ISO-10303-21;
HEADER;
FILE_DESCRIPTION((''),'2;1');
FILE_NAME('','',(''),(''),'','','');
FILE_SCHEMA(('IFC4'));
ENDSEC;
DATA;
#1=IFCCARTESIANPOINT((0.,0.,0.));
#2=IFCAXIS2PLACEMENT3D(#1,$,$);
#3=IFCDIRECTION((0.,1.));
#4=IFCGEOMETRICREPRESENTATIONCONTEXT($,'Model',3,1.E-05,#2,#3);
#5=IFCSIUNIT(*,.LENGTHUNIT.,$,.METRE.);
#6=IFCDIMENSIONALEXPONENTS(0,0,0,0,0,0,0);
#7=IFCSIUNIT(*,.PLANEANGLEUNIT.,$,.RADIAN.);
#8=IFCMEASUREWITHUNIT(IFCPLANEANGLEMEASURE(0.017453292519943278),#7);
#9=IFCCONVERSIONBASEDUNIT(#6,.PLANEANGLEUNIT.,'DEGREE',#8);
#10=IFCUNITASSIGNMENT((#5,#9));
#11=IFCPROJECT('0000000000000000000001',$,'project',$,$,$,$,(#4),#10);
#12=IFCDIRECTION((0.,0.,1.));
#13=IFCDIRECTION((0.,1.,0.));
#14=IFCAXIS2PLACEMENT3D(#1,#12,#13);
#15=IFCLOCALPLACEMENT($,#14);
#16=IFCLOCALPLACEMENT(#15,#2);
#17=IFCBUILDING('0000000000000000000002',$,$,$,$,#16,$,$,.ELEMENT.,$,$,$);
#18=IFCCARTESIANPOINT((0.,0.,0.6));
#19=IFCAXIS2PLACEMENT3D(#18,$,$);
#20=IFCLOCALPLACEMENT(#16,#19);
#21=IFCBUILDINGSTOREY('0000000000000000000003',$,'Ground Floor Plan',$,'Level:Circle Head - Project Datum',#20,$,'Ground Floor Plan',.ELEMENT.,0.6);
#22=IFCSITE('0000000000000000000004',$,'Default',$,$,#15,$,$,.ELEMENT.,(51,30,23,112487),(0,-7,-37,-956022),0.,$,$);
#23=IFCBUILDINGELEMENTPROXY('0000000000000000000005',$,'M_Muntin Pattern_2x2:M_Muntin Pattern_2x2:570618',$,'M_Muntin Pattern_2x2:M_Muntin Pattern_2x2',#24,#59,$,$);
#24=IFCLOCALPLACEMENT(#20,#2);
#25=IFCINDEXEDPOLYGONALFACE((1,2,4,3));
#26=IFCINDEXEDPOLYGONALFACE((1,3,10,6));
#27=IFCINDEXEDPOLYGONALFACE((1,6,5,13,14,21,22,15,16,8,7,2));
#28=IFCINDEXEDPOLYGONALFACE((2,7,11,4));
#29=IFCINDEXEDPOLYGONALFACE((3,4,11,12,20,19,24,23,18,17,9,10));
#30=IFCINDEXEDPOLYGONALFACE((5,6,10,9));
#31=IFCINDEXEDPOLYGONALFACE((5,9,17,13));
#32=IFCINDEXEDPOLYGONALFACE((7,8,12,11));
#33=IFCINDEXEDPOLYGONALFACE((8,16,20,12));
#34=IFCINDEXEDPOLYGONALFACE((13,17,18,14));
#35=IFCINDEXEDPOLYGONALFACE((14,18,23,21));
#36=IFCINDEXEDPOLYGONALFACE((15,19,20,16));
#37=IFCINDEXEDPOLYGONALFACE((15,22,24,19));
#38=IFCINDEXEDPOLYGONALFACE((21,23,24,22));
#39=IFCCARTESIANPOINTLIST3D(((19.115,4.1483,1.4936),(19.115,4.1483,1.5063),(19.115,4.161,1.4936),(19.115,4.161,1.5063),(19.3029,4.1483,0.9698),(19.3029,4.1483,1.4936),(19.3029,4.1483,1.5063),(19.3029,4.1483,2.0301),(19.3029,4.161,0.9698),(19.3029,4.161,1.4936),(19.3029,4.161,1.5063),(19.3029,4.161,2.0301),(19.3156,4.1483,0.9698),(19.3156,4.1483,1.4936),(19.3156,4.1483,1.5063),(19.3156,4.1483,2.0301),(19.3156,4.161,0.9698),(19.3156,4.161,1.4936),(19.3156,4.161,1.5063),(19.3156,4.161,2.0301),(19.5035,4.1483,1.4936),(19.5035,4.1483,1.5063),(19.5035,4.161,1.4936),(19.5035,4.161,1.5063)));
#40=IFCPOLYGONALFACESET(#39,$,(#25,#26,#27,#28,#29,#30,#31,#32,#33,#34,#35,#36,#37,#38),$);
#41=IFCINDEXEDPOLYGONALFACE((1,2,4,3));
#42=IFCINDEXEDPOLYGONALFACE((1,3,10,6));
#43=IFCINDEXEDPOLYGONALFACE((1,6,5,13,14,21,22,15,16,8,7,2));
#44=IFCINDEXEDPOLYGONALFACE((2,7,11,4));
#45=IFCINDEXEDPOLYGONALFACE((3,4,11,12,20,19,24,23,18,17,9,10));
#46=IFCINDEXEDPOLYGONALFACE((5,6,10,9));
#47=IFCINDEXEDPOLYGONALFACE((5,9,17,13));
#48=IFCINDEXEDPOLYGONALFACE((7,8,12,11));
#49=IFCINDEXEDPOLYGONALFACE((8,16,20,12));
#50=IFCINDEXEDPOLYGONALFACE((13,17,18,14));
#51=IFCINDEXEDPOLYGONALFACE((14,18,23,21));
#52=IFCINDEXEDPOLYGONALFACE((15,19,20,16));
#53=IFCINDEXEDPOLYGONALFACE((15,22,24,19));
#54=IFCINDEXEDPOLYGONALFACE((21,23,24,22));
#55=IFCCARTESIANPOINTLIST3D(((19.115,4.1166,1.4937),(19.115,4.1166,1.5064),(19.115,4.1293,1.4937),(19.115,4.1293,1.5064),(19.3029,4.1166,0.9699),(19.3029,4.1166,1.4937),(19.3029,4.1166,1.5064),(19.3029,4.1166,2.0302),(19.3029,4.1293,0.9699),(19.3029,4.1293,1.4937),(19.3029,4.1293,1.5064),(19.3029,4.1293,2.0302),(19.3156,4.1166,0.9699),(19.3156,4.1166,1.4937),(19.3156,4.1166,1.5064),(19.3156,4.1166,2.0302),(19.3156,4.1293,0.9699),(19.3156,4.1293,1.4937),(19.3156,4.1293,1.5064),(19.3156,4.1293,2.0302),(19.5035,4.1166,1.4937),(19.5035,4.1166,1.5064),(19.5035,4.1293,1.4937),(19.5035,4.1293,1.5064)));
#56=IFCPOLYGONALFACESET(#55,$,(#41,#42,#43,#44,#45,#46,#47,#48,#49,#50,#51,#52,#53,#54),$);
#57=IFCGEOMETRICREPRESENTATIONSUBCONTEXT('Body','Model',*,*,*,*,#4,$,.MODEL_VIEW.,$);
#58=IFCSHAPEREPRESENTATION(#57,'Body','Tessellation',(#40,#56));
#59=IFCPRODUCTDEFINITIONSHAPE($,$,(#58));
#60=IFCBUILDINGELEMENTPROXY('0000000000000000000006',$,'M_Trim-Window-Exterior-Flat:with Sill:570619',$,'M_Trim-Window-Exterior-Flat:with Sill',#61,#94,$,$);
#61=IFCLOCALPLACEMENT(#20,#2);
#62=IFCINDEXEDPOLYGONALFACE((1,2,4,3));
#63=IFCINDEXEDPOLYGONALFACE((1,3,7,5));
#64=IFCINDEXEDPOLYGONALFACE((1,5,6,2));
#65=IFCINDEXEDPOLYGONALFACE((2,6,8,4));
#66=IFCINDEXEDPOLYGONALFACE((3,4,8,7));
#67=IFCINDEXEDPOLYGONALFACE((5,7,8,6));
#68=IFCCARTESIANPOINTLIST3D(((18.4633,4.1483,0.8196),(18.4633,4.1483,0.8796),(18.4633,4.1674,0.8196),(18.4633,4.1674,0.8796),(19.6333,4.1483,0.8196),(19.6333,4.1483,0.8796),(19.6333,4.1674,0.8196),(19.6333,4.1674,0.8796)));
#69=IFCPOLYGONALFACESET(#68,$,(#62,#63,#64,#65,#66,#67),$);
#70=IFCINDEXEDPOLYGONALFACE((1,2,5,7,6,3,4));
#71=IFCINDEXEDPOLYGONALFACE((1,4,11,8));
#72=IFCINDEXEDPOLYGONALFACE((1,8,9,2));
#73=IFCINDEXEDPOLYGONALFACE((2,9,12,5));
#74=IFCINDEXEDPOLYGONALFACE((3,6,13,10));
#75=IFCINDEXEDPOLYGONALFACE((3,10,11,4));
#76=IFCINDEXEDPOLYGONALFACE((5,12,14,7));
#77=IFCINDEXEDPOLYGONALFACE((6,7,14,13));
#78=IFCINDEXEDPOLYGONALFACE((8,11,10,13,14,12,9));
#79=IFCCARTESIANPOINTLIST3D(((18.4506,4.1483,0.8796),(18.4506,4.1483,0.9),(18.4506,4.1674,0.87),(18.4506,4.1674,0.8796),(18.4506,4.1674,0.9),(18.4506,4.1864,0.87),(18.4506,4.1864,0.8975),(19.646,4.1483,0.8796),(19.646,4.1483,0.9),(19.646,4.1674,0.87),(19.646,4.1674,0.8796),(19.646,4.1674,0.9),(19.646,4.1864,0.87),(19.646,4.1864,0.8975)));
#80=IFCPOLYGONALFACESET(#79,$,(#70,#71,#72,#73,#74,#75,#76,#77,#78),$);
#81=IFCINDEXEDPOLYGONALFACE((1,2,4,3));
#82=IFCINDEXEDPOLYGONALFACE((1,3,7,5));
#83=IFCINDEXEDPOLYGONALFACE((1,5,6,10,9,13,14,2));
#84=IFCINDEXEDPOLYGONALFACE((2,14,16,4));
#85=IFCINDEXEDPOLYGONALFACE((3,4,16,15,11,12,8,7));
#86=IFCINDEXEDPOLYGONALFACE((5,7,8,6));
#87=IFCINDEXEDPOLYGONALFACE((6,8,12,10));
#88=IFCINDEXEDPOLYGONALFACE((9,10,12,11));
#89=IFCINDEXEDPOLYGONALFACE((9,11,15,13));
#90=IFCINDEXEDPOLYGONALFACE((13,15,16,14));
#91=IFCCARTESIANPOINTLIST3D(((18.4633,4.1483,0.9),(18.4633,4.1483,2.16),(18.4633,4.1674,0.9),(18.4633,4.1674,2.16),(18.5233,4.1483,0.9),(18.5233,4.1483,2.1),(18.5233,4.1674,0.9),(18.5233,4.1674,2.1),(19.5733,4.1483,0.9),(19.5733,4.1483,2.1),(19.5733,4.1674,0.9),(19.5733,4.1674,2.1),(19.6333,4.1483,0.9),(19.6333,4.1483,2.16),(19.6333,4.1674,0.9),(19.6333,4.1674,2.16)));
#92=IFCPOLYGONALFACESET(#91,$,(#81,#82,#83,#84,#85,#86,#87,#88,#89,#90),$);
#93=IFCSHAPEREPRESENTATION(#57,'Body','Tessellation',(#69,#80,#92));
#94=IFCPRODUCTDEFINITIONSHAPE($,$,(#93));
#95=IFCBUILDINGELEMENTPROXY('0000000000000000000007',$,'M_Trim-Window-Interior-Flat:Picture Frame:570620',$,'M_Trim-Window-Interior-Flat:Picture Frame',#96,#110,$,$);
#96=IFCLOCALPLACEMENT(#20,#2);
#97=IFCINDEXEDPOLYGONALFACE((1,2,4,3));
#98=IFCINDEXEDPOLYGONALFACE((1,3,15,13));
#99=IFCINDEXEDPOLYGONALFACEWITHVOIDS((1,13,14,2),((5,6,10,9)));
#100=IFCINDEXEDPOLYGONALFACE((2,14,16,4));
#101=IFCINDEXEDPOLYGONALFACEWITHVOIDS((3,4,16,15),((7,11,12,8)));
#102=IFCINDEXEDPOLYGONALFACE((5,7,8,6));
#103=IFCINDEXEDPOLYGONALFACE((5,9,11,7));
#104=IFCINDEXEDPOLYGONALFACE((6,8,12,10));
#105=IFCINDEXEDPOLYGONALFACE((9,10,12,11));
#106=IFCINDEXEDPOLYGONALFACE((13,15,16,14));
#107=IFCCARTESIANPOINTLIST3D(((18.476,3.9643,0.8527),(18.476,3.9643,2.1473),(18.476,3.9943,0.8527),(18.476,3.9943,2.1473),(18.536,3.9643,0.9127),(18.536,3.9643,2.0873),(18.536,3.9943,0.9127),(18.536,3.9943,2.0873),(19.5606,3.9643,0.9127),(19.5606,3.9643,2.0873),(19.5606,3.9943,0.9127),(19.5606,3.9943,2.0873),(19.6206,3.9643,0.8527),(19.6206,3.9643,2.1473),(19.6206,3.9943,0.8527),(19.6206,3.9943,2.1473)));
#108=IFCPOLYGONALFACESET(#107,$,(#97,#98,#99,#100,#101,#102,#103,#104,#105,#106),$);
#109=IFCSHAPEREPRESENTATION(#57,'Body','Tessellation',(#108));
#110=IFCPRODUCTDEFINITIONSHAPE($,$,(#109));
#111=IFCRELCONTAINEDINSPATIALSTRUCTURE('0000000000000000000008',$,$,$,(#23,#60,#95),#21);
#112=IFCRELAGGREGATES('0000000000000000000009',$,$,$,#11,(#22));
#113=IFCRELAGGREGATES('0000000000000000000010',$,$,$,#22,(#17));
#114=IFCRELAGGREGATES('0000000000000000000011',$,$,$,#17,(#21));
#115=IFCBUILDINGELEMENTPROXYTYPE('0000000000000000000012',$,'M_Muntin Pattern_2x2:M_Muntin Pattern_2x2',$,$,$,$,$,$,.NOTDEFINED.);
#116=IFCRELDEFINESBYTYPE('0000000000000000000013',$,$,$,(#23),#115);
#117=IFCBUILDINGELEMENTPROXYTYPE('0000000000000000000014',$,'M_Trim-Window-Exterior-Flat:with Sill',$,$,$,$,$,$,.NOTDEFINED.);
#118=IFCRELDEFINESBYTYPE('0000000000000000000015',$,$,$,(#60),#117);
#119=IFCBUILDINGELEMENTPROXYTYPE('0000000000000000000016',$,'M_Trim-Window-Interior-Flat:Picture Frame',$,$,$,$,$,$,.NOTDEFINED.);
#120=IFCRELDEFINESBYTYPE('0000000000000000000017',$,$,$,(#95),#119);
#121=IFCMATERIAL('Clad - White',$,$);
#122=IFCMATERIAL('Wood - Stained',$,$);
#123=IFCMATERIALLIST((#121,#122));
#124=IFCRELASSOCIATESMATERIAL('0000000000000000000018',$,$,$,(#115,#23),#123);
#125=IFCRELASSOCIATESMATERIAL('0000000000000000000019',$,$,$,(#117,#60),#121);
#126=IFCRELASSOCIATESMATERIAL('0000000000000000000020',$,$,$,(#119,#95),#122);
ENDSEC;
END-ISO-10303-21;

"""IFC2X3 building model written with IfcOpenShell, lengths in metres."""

from ifc_helpers import new_model, entity, si_unit, converted_unit, direction, frame, frame_2d, origin, place, context, subcontext, project, spatial, polyline, rectangle, outline, extrude, source, transform, mapped, material, material_list, type_object, type_shapes, element, save


model = new_model("IFC2X3")

# Units and contexts
model_context = context("Model", 3, precision=1e-05, world=origin(), true_north=direction((0.0, 1.0)))
body_context = subcontext(model_context, "Body", "Model", "MODEL_VIEW")
ifc_project = project(units=[si_unit("LENGTHUNIT", "METRE"), converted_unit("PLANEANGLEUNIT", "DEGREE", entity("IfcPlaneAngleMeasure", 0.017453292519943278), si_unit("PLANEANGLEUNIT", "RADIAN"), dimensions=[0, 0, 0, 0, 0, 0, 0])], contexts=[model_context])

# Site, building, storey
site_placement = place(None, frame((0.0, 0.0, 0.0), z_axis=(0.0, 0.0, 1.0), x_axis=(0.0, 1.0, 0.0)))
site = spatial("IfcSite", under=ifc_project, at=site_placement, Name="Default", CompositionType="ELEMENT", RefLatitude=(51, 30, 23, 112487), RefLongitude=(0, -7, -37, -956022), RefElevation=0.0)
building_placement = place(site_placement, origin())
building = spatial("IfcBuilding", under=site, at=building_placement, CompositionType="ELEMENT")
storey_placement = place(building_placement, frame((0.0, 0.0, 0.6)))
storey = spatial("IfcBuildingStorey", under=building, at=storey_placement, Name="Ground Floor Plan", ObjectType="Level:Circle Head - Project Datum", LongName="Ground Floor Plan", CompositionType="ELEMENT", Elevation=0.6)

# Building element proxies
ifc_material_1 = material(Name="Clad - White")
ifc_material_2 = material(Name="Wood - Stained")
ifc_material_list = material_list([ifc_material_1, ifc_material_2])
building_element_proxy_type_1 = type_object("IfcBuildingElementProxyType", Name="M_Muntin Pattern_2x2:M_Muntin Pattern_2x2", PredefinedType="NOTDEFINED", material=ifc_material_list)
shared_shape_1 = source(origin(), body_context, "Body", "SweptSolid", [
    extrude(outline(polyline([(0.0064, -0.0064), (0.5301, -0.0064), (0.5301, 0.0063), (0.0064, 0.0063), (0.0064, 0.1942), (-0.0063, 0.1942), (-0.0063, 0.0063), (-0.5302, 0.0063), (-0.5302, -0.0064), (-0.0063, -0.0064), (-0.0063, -0.1942), (0.0064, -0.1942), (0.0064, -0.0064)])), frame((0.0, -0.0222, 0.5301), z_axis=(0.0, 1.0, 0.0), x_axis=(0.0, 0.0, 1.0)), (0.0, 0.0, 1.0), 0.0127),
    extrude(outline(polyline([(0.0064, -0.0064), (0.5302, -0.0064), (0.5302, 0.0063), (0.0064, 0.0063), (0.0064, 0.1942), (-0.0063, 0.1942), (-0.0063, 0.0063), (-0.5302, 0.0063), (-0.5302, -0.0064), (-0.0063, -0.0064), (-0.0063, -0.1942), (0.0064, -0.1942), (0.0064, -0.0064)])), frame((0.0, 0.0095, 0.5302), z_axis=(0.0, 1.0, 0.0), x_axis=(0.0, 0.0, 1.0)), (0.0, 0.0, 1.0), 0.0127),
])
type_shapes(building_element_proxy_type_1, [shared_shape_1])
proxy_1_placement = place(storey_placement, frame((19.3092, 4.1388, 0.9699), z_axis=(0.0, 0.0, 1.0), x_axis=(-1.0, 0.0, 0.0)))
element("IfcBuildingElementProxy", 1, at=proxy_1_placement, inside=storey, type_object=building_element_proxy_type_1, material=ifc_material_list, Name="M_Muntin Pattern_2x2:M_Muntin Pattern_2x2:570618", ObjectType="M_Muntin Pattern_2x2:M_Muntin Pattern_2x2", context=body_context, shape_type="MappedRepresentation", body=[
    mapped(shared_shape_1, transform((0.0, 0.0, 0.0), scale=1.0)),
])
building_element_proxy_type_2 = type_object("IfcBuildingElementProxyType", Name="M_Trim-Window-Exterior-Flat:with Sill", PredefinedType="NOTDEFINED", material=ifc_material_1)
shared_shape_2 = source(origin(), body_context, "Body", "SweptSolid", [
    extrude(rectangle(XDim=1.17, YDim=0.06, at=frame_2d((0.0, 0.0), x_axis=(1.0, 0.0))), frame((0.0, -1.2504, 0.0), z_axis=(0.0, 0.0, 1.0), x_axis=(-1.0, 0.0, 0.0)), (0.0, 0.0, 1.0), 0.019),
    extrude(outline(polyline([(-0.019, -0.0152), (0.0, -0.0152), (0.0, -0.0057), (0.019, -0.0057), (0.019, 0.0148), (0.0, 0.0148), (-0.019, 0.0123), (-0.019, -0.0152)])), frame((-0.5977, -1.2148, 0.019), z_axis=(1.0, 0.0, 0.0), x_axis=(0.0, 0.0, -1.0)), (0.0, 0.0, 1.0), 1.1954),
    extrude(outline(polyline([(-0.645, -0.585), (0.615, -0.585), (0.615, -0.525), (-0.585, -0.525), (-0.585, 0.525), (0.615, 0.525), (0.615, 0.585), (-0.645, 0.585), (-0.645, -0.585)])), frame((0.0, -0.585, 0.0), z_axis=(0.0, 0.0, 1.0), x_axis=(0.0, -1.0, 0.0)), (0.0, 0.0, 1.0), 0.019),
])
type_shapes(building_element_proxy_type_2, [shared_shape_2])
proxy_2_placement = place(storey_placement, frame((19.0483, 4.1483, 2.1), z_axis=(0.0, 1.0, 0.0), x_axis=(-1.0, 0.0, 0.0)))
element("IfcBuildingElementProxy", 2, at=proxy_2_placement, inside=storey, type_object=building_element_proxy_type_2, material=ifc_material_1, Name="M_Trim-Window-Exterior-Flat:with Sill:570619", ObjectType="M_Trim-Window-Exterior-Flat:with Sill", context=body_context, shape_type="MappedRepresentation", body=[
    mapped(shared_shape_2, transform((0.0, 0.0, 0.0), scale=1.0)),
])
building_element_proxy_type_3 = type_object("IfcBuildingElementProxyType", Name="M_Trim-Window-Interior-Flat:Picture Frame", PredefinedType="NOTDEFINED", material=ifc_material_2)
shared_shape_3 = source(origin(), body_context, "Body", "SweptSolid", [
    extrude(outline(polyline([(-0.5723, -0.6473), (0.5723, -0.6473), (0.5723, 0.6473), (-0.5723, 0.6473), (-0.5723, -0.6473)]), holes=[polyline([(-0.5123, -0.5873), (-0.5123, 0.5873), (0.5123, 0.5873), (0.5123, -0.5873), (-0.5123, -0.5873)])]), frame((0.0, -0.6, 0.0), z_axis=(0.0, 0.0, 1.0), x_axis=(-1.0, 0.0, 0.0)), (0.0, 0.0, 1.0), 0.03),
])
type_shapes(building_element_proxy_type_3, [shared_shape_3])
proxy_3_placement = place(storey_placement, frame((19.0483, 3.9943, 2.1), z_axis=(0.0, -1.0, 0.0), x_axis=(1.0, 0.0, 0.0)))
element("IfcBuildingElementProxy", 3, at=proxy_3_placement, inside=storey, type_object=building_element_proxy_type_3, material=ifc_material_2, Name="M_Trim-Window-Interior-Flat:Picture Frame:570620", ObjectType="M_Trim-Window-Interior-Flat:Picture Frame", context=body_context, shape_type="MappedRepresentation", body=[
    mapped(shared_shape_3, transform((0.0, 0.0, 0.0), scale=1.0)),
])

save(model, "model.ifc")
